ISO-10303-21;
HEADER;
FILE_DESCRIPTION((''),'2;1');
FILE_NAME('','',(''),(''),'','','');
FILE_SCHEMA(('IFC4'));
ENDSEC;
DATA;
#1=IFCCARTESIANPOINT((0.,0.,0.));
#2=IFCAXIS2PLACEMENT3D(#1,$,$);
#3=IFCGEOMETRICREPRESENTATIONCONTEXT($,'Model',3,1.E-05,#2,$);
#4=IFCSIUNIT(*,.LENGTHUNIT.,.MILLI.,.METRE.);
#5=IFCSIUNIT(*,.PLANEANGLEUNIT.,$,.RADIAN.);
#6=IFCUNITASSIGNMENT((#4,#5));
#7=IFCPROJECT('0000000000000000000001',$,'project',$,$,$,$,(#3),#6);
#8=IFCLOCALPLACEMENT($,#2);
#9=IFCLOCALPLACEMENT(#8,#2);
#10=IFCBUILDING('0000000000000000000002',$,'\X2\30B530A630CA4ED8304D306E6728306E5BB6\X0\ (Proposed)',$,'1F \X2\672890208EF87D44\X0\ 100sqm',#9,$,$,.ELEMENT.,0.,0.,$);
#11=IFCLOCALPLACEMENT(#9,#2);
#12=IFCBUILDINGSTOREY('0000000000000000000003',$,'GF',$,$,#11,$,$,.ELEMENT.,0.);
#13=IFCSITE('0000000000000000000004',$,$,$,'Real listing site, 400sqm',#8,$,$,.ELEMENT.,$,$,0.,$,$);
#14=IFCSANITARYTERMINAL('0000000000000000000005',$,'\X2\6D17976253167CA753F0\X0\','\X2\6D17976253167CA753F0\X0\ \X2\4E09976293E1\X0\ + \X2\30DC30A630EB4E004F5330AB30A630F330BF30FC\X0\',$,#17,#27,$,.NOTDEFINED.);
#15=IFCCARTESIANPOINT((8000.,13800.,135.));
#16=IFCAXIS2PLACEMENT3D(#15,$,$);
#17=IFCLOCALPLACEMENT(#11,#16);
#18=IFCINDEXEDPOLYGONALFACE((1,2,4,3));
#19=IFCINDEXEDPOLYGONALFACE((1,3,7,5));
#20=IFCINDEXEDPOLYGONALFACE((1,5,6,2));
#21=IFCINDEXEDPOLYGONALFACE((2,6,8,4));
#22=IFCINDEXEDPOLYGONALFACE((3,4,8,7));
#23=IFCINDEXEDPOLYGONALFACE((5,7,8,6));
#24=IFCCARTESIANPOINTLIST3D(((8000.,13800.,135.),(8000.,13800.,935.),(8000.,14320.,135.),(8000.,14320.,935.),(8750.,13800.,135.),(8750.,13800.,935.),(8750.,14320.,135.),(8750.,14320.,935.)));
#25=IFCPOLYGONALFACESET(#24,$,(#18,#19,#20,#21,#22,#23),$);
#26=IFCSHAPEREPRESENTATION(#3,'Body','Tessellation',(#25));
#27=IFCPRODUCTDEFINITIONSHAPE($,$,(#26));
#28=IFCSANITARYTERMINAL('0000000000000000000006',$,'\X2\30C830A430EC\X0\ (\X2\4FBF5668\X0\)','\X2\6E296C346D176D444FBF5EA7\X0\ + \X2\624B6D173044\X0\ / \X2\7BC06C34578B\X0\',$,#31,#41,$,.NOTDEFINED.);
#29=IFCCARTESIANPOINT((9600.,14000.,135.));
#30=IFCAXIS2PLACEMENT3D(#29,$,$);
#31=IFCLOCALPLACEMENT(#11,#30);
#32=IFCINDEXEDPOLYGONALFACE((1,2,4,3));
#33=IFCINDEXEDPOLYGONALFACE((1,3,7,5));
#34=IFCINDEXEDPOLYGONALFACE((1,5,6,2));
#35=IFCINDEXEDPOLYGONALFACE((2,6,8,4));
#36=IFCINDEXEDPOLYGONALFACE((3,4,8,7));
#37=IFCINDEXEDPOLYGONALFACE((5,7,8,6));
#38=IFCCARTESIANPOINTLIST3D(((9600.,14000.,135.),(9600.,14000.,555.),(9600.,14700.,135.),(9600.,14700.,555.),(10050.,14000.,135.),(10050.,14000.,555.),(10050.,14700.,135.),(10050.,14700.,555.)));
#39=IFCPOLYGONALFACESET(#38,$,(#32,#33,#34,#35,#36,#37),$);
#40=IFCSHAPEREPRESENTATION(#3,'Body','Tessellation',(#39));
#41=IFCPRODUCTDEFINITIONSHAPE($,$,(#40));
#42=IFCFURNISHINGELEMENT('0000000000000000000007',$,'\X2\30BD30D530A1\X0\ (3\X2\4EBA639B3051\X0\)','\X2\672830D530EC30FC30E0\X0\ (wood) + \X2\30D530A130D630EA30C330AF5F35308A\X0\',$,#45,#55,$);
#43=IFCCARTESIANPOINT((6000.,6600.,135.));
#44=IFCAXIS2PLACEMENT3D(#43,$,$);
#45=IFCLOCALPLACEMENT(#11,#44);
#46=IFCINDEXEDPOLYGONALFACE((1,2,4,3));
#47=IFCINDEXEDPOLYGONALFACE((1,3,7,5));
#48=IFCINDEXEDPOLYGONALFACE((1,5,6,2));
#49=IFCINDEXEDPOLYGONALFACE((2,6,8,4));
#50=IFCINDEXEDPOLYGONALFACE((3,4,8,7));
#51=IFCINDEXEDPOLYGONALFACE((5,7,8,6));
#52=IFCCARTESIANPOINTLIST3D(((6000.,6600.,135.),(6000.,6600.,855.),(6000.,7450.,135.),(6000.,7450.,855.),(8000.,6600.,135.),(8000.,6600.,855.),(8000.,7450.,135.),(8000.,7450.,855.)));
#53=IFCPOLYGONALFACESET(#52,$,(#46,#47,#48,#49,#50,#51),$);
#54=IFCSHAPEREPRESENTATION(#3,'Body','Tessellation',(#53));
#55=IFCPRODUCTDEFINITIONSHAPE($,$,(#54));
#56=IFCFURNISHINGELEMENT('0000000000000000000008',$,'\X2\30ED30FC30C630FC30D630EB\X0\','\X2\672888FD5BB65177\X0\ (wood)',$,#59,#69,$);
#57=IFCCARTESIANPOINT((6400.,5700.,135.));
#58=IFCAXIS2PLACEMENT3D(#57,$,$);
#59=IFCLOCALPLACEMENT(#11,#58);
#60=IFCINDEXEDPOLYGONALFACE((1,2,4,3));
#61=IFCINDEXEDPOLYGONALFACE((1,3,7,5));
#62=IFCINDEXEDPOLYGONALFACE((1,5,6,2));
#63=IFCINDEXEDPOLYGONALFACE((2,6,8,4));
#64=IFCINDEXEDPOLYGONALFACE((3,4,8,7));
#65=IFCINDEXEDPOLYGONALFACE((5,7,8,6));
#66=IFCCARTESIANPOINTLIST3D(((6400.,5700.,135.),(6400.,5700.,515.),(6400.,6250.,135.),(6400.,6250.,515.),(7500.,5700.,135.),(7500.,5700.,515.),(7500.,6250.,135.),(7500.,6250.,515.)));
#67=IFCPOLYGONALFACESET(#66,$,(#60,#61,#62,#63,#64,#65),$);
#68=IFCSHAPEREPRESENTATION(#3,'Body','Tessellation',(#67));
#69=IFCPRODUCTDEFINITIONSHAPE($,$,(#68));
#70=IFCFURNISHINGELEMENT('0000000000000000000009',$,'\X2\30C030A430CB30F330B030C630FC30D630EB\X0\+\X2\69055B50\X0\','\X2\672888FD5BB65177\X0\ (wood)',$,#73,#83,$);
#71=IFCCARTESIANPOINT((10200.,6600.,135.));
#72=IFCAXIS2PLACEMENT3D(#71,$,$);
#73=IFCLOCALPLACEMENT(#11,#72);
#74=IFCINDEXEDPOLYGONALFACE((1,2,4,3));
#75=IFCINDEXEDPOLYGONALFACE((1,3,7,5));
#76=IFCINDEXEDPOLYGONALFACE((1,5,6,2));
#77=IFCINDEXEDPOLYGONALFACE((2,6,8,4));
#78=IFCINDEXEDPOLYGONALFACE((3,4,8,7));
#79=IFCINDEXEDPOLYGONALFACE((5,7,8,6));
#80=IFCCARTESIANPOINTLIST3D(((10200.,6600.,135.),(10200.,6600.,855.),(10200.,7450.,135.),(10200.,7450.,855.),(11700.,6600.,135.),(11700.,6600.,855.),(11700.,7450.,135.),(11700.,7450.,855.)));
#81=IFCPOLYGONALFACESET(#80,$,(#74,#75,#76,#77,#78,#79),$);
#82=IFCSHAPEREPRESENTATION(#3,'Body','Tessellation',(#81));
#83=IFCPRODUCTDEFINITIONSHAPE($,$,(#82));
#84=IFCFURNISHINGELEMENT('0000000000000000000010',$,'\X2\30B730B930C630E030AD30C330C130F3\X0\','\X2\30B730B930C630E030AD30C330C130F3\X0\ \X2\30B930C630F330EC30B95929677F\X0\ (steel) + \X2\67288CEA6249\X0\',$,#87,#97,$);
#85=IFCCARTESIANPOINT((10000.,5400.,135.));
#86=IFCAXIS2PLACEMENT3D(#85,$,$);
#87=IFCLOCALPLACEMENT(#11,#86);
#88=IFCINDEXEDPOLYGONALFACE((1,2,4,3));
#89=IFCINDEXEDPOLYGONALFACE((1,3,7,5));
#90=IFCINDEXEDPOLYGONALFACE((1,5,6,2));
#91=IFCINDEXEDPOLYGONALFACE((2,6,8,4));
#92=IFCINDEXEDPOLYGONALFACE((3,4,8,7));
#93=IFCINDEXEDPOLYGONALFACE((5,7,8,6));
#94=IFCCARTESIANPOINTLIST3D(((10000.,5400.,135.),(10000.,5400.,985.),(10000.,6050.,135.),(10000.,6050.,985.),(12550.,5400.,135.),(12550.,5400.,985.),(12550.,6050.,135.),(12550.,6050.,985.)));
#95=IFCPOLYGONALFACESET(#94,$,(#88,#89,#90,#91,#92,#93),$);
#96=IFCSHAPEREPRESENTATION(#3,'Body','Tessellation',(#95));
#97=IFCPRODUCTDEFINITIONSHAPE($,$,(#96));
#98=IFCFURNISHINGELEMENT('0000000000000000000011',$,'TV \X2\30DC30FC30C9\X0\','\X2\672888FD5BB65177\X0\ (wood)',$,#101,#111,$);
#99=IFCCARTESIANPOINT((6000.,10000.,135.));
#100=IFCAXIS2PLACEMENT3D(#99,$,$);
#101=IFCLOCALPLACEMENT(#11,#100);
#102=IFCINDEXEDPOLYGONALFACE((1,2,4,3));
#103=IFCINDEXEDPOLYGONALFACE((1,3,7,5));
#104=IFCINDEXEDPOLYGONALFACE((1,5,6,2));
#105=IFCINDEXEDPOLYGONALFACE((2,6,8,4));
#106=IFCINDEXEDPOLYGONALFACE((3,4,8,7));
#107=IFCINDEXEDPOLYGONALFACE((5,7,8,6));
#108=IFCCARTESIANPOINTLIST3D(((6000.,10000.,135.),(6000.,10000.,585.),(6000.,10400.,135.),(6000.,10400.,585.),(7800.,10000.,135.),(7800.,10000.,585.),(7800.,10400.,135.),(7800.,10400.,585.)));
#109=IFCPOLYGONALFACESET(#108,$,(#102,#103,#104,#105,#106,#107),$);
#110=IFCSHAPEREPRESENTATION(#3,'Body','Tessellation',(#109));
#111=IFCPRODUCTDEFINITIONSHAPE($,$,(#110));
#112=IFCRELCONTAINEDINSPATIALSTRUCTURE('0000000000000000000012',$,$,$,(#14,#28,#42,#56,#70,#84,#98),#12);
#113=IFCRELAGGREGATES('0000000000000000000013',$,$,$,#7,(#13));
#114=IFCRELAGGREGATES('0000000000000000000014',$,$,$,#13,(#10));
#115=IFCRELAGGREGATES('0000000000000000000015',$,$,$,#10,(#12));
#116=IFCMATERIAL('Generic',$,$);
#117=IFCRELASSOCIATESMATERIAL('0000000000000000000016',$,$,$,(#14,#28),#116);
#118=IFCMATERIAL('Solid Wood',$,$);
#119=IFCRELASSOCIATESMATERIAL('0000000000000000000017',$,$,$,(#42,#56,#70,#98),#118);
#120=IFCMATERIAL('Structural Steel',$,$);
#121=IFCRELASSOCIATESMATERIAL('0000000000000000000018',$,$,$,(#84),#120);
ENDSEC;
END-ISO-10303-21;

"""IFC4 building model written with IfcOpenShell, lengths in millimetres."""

from ifc_helpers import new_model, si_unit, frame, frame_2d, origin, place, context, project, spatial, rectangle, extrude, material, element, save


model = new_model("IFC4")

# Units and contexts
model_context = context("Model", 3, precision=1e-05, world=origin())
ifc_project = project(units=[si_unit("LENGTHUNIT", "METRE", prefix="MILLI"), si_unit("PLANEANGLEUNIT", "RADIAN")], contexts=[model_context])

# Site, building, storey
site_placement = place(None, origin())
site = spatial("IfcSite", under=ifc_project, at=site_placement, ObjectType="Real listing site, 400sqm", CompositionType="ELEMENT", RefElevation=0.0)
building_placement = place(site_placement, origin())
building = spatial("IfcBuilding", under=site, at=building_placement, Name="サウナ付きの木の家 (Proposed)", ObjectType="1F 木造軸組 100sqm", CompositionType="ELEMENT", ElevationOfRefHeight=0.0, ElevationOfTerrain=0.0)
storey_placement = place(building_placement, origin())
storey = spatial("IfcBuildingStorey", under=building, at=storey_placement, Name="GF", CompositionType="ELEMENT", Elevation=0.0)

# Shared definitions
ifc_material_1 = material(Name="Solid Wood")

# Shared definitions
ifc_material_2 = material(Name="Structural Steel")

# Shared definitions
ifc_material_3 = material(Name="Generic")

# Sanitary terminals
sanitary_terminal_1_placement = place(storey_placement, frame((8000.0, 13800.0, 135.0)))
element("IfcSanitaryTerminal", 1, at=sanitary_terminal_1_placement, inside=storey, material=ifc_material_3, Name="洗面化粧台", Description="洗面化粧台 三面鏡 + ボウル一体カウンター", PredefinedType="NOTDEFINED", context=model_context, shape_type="SweptSolid", body=[
    extrude(rectangle(XDim=750.0, YDim=520.0, at=frame_2d((375.0, 260.0))), frame((8000.0, 13800.0, 135.0)), (0.0, 0.0, 1.0), 800.0),
])
sanitary_terminal_2_placement = place(storey_placement, frame((9600.0, 14000.0, 135.0)))
element("IfcSanitaryTerminal", 2, at=sanitary_terminal_2_placement, inside=storey, material=ifc_material_3, Name="トイレ (便器)", Description="温水洗浄便座 + 手洗い / 節水型", PredefinedType="NOTDEFINED", context=model_context, shape_type="SweptSolid", body=[
    extrude(rectangle(XDim=450.0, YDim=700.0, at=frame_2d((225.0, 350.0))), frame((9600.0, 14000.0, 135.0)), (0.0, 0.0, 1.0), 420.0),
])

# Furnishing elements
furnishing_1_placement = place(storey_placement, frame((6000.0, 6600.0, 135.0)))
element("IfcFurnishingElement", 3, at=furnishing_1_placement, inside=storey, material=ifc_material_1, Name="ソファ (3人掛け)", Description="木フレーム (wood) + ファブリック張り", context=model_context, shape_type="SweptSolid", body=[
    extrude(rectangle(XDim=2000.0, YDim=850.0, at=frame_2d((1000.0, 425.0))), frame((6000.0, 6600.0, 135.0)), (0.0, 0.0, 1.0), 720.0),
])
furnishing_2_placement = place(storey_placement, frame((6400.0, 5700.0, 135.0)))
element("IfcFurnishingElement", 4, at=furnishing_2_placement, inside=storey, material=ifc_material_1, Name="ローテーブル", Description="木製家具 (wood)", context=model_context, shape_type="SweptSolid", body=[
    extrude(rectangle(XDim=1100.0, YDim=550.0, at=frame_2d((550.0, 275.0))), frame((6400.0, 5700.0, 135.0)), (0.0, 0.0, 1.0), 380.0),
])
furnishing_3_placement = place(storey_placement, frame((10200.0, 6600.0, 135.0)))
element("IfcFurnishingElement", 5, at=furnishing_3_placement, inside=storey, material=ifc_material_1, Name="ダイニングテーブル+椅子", Description="木製家具 (wood)", context=model_context, shape_type="SweptSolid", body=[
    extrude(rectangle(XDim=1500.0, YDim=850.0, at=frame_2d((750.0, 425.0))), frame((10200.0, 6600.0, 135.0)), (0.0, 0.0, 1.0), 720.0),
])
furnishing_4_placement = place(storey_placement, frame((10000.0, 5400.0, 135.0)))
element("IfcFurnishingElement", 6, at=furnishing_4_placement, inside=storey, material=ifc_material_2, Name="システムキッチン", Description="システムキッチン ステンレス天板 (steel) + 木質扉", context=model_context, shape_type="SweptSolid", body=[
    extrude(rectangle(XDim=2550.0, YDim=650.0, at=frame_2d((1275.0, 325.0))), frame((10000.0, 5400.0, 135.0)), (0.0, 0.0, 1.0), 850.0),
])
furnishing_5_placement = place(storey_placement, frame((6000.0, 10000.0, 135.0)))
element("IfcFurnishingElement", 7, at=furnishing_5_placement, inside=storey, material=ifc_material_1, Name="TV ボード", Description="木製家具 (wood)", context=model_context, shape_type="SweptSolid", body=[
    extrude(rectangle(XDim=1800.0, YDim=400.0, at=frame_2d((900.0, 200.0))), frame((6000.0, 10000.0, 135.0)), (0.0, 0.0, 1.0), 450.0),
])

save(model, "model.ifc")
